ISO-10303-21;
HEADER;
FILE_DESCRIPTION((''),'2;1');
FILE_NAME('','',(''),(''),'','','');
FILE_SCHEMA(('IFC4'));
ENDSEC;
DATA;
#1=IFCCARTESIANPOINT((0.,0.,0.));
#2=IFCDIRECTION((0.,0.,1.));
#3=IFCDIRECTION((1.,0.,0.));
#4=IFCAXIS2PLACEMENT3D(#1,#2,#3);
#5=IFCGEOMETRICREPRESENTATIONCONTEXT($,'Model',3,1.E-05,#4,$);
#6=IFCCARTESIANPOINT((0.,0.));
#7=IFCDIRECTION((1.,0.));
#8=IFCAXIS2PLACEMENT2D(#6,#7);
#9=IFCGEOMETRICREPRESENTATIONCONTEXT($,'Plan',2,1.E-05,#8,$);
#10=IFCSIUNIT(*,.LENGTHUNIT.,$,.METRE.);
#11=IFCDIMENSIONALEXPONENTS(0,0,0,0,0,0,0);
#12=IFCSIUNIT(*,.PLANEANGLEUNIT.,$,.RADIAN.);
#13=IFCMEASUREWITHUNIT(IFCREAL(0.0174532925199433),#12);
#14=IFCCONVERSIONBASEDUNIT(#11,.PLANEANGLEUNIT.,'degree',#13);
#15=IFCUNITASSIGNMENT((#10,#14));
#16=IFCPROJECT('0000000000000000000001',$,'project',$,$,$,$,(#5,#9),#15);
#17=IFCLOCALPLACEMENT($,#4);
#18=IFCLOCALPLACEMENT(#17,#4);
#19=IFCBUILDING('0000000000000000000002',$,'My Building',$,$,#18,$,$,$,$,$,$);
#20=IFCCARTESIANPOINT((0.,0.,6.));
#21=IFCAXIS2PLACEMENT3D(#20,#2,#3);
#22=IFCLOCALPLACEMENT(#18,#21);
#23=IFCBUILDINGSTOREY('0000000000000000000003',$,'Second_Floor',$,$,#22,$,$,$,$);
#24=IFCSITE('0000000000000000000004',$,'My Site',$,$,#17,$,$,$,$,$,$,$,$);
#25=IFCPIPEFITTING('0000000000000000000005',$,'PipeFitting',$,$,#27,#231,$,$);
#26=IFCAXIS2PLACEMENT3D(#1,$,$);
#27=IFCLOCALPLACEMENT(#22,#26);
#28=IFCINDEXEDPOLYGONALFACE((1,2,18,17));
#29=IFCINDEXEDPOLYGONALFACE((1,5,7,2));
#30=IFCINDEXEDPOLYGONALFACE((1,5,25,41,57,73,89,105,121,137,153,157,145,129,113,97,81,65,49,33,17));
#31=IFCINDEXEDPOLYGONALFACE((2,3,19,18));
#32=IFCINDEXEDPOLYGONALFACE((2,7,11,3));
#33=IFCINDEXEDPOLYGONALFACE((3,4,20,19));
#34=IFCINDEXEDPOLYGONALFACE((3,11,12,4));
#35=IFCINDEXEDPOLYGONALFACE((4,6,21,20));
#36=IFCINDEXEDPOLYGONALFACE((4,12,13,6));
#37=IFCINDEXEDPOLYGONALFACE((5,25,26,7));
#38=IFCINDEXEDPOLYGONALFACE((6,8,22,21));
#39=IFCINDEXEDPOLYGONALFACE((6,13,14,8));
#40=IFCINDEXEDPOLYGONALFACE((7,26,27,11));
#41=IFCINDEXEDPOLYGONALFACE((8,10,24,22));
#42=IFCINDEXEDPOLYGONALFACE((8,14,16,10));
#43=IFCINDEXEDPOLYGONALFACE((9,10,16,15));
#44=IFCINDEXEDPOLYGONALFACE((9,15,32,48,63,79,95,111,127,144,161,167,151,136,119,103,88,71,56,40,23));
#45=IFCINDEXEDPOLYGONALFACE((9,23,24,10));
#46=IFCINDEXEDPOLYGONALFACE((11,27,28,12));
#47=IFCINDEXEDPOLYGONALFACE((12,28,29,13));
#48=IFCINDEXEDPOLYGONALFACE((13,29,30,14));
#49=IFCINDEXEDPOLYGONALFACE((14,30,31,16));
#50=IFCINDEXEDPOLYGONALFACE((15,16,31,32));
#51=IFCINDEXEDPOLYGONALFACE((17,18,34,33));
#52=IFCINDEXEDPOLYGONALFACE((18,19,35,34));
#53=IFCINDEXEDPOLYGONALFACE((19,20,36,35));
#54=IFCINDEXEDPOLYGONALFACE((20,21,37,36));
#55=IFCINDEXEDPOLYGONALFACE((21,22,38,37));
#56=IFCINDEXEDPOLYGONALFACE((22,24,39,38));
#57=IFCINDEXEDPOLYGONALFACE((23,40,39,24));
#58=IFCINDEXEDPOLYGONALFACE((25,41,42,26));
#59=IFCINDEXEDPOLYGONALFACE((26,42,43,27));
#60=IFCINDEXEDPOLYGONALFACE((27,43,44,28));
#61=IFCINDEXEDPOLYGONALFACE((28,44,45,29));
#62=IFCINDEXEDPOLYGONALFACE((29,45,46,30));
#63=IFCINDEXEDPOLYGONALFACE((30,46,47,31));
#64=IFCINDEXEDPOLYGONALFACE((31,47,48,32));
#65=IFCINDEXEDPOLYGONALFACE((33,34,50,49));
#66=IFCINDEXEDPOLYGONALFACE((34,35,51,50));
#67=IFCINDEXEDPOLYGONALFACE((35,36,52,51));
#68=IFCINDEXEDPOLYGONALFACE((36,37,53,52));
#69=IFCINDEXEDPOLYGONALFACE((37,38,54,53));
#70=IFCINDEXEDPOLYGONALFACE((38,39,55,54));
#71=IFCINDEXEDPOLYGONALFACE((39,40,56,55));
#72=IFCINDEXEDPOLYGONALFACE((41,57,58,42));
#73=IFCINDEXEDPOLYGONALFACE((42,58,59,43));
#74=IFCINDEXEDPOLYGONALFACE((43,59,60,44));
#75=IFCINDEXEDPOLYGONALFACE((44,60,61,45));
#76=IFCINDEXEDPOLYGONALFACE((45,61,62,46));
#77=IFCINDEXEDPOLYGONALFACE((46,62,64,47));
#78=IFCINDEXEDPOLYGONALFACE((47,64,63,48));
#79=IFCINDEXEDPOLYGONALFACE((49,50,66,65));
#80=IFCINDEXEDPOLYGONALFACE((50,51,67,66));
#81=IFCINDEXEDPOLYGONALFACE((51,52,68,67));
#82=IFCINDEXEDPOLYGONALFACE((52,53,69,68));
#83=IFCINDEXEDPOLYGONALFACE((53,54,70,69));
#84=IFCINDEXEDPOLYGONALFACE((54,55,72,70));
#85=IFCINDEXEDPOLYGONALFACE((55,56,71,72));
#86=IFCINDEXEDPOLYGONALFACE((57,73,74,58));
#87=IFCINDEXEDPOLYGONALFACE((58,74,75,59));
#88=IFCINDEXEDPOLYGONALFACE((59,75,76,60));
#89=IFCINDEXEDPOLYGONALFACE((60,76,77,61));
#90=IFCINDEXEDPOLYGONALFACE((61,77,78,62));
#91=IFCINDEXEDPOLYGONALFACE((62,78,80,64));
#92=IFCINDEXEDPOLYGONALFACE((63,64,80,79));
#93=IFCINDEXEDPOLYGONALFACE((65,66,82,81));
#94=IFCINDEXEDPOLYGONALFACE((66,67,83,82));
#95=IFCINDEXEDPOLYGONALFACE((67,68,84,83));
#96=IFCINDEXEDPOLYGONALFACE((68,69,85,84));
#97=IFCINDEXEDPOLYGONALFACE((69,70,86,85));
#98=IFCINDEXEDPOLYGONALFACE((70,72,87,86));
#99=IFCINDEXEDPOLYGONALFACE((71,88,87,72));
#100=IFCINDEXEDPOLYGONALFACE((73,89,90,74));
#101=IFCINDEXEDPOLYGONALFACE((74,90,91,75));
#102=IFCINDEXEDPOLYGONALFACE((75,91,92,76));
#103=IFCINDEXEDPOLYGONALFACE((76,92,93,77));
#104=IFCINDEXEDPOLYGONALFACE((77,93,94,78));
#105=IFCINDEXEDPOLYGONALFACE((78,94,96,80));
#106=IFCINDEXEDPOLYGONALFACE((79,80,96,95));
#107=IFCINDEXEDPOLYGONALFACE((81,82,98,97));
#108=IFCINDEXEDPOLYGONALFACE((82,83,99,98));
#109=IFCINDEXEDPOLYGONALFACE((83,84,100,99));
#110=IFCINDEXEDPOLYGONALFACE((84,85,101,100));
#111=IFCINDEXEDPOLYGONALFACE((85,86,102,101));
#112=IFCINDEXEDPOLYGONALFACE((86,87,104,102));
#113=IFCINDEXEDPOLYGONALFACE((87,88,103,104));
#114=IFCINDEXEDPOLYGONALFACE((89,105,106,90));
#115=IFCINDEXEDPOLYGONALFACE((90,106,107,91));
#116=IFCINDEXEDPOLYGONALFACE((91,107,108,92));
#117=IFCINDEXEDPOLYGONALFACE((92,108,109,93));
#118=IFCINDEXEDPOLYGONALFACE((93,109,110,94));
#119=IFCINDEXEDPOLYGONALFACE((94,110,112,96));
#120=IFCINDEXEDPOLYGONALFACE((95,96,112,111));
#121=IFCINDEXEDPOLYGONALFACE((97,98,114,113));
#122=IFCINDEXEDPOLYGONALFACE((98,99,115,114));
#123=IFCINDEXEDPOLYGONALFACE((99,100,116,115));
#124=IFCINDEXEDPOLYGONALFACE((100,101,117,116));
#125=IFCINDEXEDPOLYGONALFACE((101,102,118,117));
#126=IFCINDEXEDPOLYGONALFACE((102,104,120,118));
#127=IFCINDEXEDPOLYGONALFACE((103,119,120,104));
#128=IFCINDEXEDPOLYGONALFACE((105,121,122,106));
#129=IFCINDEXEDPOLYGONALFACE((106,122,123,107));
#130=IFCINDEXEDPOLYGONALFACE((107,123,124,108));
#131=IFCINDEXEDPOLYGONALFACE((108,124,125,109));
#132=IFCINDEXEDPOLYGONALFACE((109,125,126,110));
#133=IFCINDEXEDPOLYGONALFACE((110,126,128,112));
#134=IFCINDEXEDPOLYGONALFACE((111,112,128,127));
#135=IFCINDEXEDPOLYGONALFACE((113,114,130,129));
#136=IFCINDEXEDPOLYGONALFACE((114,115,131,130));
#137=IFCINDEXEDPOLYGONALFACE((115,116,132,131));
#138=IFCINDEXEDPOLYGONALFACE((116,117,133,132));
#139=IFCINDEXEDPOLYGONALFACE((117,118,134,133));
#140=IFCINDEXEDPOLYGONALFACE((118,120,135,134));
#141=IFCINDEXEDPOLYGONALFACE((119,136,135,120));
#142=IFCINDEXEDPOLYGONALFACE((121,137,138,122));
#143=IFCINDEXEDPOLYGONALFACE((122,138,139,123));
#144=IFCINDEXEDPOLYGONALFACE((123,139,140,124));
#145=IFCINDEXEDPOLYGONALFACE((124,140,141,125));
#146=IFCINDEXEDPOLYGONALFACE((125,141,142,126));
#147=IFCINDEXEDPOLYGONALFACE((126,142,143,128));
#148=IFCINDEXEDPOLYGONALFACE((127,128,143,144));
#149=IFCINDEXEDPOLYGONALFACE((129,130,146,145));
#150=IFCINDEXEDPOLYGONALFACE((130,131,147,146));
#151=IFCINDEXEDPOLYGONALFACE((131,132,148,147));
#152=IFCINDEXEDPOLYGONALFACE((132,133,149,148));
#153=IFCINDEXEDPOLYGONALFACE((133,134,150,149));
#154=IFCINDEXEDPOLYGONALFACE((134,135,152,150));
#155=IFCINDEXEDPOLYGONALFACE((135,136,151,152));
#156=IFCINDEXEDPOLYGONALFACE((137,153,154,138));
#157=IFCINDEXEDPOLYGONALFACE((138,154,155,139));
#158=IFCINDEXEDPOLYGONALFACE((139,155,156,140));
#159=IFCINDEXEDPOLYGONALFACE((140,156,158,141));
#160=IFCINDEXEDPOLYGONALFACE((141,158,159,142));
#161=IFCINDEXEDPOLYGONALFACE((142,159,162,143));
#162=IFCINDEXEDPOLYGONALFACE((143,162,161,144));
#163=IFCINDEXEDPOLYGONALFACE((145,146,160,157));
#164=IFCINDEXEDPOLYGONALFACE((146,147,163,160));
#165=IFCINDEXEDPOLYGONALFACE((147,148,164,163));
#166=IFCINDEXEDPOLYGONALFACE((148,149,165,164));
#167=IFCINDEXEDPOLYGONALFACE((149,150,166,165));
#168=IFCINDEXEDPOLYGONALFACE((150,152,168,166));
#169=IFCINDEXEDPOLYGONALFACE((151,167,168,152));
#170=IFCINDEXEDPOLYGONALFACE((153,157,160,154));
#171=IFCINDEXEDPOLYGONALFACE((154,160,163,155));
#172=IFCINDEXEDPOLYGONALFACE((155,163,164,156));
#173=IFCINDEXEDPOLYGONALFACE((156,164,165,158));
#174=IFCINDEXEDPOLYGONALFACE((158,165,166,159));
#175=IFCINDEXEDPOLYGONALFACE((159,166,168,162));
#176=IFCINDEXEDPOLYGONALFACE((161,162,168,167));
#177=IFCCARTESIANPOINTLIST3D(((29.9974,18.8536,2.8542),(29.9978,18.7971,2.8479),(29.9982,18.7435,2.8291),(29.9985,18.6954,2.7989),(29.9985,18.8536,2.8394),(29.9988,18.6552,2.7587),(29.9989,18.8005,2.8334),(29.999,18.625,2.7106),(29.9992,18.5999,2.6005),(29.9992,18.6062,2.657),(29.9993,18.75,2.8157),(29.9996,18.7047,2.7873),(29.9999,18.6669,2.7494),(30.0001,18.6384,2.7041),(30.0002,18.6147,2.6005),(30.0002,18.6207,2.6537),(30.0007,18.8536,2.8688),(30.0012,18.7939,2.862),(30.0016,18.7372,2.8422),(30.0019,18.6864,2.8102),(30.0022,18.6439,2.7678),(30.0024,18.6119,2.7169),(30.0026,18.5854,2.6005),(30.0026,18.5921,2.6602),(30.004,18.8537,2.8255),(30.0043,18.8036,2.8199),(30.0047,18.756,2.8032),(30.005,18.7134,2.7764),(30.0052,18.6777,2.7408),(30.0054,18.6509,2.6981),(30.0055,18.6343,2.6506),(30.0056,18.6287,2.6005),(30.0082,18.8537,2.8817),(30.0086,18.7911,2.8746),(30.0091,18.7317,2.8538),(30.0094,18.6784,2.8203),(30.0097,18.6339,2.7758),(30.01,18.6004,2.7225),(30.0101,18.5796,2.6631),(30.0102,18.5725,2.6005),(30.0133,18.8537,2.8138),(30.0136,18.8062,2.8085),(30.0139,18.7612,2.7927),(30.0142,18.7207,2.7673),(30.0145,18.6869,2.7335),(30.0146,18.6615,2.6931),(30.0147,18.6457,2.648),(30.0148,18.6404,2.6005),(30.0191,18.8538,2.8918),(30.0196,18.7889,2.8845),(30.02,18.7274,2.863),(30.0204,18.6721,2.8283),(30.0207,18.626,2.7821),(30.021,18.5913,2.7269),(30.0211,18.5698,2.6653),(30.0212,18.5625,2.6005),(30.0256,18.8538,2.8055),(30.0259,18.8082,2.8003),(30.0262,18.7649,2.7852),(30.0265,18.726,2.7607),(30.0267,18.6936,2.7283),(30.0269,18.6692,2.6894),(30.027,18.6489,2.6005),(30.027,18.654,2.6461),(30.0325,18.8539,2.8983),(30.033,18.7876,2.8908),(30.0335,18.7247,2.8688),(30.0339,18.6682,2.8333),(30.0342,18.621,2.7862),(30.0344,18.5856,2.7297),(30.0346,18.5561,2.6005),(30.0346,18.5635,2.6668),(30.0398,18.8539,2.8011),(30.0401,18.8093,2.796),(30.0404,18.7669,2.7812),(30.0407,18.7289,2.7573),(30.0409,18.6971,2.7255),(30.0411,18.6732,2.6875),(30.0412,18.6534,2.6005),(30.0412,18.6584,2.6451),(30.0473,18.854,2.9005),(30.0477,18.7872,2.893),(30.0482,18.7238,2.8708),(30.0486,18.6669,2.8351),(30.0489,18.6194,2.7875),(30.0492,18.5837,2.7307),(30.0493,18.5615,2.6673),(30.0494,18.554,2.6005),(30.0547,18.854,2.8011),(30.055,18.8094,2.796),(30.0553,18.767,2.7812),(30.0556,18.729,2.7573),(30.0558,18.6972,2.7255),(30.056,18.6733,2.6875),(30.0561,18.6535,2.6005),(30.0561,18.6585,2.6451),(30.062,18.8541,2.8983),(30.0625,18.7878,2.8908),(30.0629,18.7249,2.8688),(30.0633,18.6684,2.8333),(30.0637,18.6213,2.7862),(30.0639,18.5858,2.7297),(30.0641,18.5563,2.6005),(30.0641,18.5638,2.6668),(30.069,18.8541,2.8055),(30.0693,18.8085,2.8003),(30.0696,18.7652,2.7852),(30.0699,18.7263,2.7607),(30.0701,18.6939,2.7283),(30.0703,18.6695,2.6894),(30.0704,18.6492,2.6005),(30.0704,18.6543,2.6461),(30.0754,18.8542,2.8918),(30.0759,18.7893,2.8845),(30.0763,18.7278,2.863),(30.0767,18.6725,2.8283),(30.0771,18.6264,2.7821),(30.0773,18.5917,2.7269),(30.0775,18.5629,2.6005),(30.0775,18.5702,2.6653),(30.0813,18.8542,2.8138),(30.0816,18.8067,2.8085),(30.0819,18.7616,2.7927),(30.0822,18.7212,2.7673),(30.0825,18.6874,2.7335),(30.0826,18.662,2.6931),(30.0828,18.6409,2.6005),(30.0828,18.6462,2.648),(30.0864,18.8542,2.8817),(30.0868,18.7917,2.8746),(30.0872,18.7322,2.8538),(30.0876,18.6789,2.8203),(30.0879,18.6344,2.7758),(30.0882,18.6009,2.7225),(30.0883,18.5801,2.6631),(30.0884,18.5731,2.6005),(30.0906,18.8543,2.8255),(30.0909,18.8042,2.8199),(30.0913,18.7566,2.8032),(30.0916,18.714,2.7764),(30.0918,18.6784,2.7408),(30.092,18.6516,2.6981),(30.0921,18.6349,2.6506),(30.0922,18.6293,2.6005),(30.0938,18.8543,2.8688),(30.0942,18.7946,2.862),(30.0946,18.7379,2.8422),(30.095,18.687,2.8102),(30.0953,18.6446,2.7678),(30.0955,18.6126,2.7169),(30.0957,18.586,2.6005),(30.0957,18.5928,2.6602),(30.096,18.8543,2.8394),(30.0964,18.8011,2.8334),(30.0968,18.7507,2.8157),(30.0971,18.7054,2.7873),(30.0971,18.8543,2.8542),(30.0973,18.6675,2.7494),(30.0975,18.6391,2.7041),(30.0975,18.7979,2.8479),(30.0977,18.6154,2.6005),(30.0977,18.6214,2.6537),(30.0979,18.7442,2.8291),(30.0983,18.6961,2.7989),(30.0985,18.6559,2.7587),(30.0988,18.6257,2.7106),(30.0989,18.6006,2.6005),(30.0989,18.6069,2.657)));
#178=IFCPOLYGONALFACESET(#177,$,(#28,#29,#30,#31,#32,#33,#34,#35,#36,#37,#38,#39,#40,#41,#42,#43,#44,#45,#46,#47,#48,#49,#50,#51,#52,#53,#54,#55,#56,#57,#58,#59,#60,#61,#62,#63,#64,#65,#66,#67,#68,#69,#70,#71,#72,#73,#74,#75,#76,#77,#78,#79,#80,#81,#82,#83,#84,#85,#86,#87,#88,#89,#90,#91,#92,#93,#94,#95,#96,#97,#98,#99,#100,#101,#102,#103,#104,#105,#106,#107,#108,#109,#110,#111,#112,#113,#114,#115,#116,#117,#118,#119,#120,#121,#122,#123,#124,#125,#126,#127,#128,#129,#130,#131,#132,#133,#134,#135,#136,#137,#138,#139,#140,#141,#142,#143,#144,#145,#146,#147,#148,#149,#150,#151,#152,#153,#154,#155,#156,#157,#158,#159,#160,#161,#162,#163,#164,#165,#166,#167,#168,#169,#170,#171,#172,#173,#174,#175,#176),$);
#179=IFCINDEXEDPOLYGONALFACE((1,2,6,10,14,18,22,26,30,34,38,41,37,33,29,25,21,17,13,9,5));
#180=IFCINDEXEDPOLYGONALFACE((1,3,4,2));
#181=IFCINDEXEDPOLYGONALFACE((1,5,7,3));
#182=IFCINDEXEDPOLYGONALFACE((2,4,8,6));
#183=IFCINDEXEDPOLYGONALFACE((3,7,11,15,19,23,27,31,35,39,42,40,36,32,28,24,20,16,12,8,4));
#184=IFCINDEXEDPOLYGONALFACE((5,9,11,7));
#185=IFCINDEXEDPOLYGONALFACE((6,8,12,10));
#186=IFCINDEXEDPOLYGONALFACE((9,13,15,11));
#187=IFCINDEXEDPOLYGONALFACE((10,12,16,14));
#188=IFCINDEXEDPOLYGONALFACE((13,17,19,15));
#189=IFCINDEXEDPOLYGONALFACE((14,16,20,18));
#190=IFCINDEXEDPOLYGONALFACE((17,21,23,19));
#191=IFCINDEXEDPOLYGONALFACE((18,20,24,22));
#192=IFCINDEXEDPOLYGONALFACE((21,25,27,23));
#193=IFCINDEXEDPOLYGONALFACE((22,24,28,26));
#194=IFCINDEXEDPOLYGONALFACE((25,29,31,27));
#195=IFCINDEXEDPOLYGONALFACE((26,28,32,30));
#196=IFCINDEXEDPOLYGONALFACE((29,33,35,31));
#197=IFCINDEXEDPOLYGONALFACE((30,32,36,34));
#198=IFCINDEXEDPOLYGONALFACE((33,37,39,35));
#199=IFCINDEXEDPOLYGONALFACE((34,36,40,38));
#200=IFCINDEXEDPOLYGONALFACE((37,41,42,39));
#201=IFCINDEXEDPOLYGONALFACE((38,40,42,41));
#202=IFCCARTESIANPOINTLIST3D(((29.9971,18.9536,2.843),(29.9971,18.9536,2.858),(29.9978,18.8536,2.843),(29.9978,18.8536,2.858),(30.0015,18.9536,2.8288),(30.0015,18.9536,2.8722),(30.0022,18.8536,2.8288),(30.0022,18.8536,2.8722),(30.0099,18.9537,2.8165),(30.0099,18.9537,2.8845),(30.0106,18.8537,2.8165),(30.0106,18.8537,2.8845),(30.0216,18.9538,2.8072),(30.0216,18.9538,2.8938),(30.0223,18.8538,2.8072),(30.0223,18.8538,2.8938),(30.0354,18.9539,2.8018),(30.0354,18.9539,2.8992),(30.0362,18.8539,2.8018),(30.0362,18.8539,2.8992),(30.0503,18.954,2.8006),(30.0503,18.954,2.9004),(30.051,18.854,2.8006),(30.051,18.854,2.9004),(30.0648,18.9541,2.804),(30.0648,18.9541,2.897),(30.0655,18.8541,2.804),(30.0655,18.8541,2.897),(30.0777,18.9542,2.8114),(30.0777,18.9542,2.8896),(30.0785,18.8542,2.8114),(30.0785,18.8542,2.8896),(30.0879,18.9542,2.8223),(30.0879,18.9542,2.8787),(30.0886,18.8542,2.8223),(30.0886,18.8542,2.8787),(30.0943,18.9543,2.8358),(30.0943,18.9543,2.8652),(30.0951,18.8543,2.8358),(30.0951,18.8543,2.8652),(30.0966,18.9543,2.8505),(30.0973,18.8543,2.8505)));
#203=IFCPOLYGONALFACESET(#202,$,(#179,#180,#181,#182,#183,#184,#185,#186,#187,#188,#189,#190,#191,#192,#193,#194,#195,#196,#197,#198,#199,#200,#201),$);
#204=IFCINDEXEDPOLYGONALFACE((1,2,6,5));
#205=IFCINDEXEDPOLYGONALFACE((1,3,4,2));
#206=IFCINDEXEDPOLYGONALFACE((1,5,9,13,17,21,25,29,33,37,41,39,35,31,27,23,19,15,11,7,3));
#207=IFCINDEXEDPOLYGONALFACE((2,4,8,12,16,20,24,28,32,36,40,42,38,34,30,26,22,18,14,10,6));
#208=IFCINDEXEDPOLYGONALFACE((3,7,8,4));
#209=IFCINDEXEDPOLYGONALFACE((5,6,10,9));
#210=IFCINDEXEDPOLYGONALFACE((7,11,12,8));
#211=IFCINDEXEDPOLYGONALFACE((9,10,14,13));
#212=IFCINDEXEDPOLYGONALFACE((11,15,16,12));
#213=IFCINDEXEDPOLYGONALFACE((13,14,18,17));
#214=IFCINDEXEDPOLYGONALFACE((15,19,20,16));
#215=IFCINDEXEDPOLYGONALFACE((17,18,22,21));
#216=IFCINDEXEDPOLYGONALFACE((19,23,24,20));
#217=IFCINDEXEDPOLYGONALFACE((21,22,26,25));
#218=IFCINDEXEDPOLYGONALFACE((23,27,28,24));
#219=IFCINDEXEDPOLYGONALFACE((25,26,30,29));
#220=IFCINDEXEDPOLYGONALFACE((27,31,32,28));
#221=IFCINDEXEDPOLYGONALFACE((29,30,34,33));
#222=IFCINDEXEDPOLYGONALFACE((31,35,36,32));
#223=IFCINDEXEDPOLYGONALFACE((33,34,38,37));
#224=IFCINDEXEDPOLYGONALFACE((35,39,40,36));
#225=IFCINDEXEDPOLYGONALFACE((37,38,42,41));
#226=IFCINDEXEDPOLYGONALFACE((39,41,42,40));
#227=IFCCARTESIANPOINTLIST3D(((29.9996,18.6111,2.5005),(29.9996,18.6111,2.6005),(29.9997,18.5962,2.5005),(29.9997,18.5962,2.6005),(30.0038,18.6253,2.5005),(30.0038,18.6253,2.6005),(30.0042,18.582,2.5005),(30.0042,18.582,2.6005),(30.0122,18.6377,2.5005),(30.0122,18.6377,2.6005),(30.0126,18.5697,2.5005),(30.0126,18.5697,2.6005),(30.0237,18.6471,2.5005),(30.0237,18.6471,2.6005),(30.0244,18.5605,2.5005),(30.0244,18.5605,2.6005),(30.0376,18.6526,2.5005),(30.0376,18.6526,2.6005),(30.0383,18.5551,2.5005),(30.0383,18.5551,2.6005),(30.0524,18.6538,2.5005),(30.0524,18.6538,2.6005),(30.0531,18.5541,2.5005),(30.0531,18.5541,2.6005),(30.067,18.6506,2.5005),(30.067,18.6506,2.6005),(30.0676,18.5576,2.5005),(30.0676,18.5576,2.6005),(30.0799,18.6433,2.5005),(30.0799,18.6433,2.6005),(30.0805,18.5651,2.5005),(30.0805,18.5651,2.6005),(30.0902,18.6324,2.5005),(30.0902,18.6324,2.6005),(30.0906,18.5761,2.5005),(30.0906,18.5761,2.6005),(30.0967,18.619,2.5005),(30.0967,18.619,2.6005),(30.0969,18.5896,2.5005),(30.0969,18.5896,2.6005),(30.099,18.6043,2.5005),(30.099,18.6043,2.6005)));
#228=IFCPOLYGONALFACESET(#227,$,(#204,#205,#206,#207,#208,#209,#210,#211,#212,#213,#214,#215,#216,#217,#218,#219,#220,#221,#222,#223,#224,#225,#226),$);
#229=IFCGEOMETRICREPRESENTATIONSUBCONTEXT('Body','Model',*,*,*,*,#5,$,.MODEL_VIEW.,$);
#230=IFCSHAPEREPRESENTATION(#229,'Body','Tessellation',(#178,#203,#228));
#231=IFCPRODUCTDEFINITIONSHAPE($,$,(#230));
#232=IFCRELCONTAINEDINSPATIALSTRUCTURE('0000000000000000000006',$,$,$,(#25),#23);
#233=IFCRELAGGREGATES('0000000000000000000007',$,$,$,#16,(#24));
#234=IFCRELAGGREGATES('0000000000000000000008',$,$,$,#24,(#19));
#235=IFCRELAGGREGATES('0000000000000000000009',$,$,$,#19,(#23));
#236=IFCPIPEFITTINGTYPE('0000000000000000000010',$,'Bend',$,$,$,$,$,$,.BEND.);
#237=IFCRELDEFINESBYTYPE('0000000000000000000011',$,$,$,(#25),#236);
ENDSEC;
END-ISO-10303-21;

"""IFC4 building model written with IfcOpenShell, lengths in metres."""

from ifc_helpers import new_model, entity, si_unit, converted_unit, frame, origin_with_axes, origin_2d_with_axis, place, context, subcontext, project, spatial, circle, extrude, source, transform, mapped, type_object, type_shapes, element, save


model = new_model("IFC4")

# Units and contexts
model_context = context("Model", 3, precision=1e-05, world=origin_with_axes())
plan_context = context("Plan", 2, precision=1e-05, world=origin_2d_with_axis())
body_context_1 = subcontext(model_context, "Body", "Model", "MODEL_VIEW")
ifc_project = project(units=[si_unit("LENGTHUNIT", "METRE"), converted_unit("PLANEANGLEUNIT", "degree", entity("IfcReal", 0.0174532925199433), si_unit("PLANEANGLEUNIT", "RADIAN"), dimensions=[0, 0, 0, 0, 0, 0, 0])], contexts=[model_context, plan_context])

# Site, building, storey
site_placement = place(None, origin_with_axes())
site = spatial("IfcSite", under=ifc_project, at=site_placement, Name="My Site")
building_placement = place(site_placement, origin_with_axes())
building = spatial("IfcBuilding", under=site, at=building_placement, Name="My Building")
storey_placement = place(building_placement, frame((0.0, 0.0, 6.0), z_axis=(0.0, 0.0, 1.0), x_axis=(1.0, 0.0, 0.0)))
storey = spatial("IfcBuildingStorey", under=building, at=storey_placement, Name="Second_Floor")

# Pipe fitting
pipe_fitting_type = type_object("IfcPipeFittingType", Name="Bend", PredefinedType="BEND")
shared_shape_1 = source(origin_with_axes(), body_context_1, "Body", "SolidModel", [
    entity("IfcSweptDiskSolid", entity("IfcIndexedPolyCurve", entity("IfcCartesianPointList3D", [[0.0, 0.0, -0.1], [0.0, 0.0732, -0.2768], [0.0, 0.25, -0.35]]), [entity("IfcArcIndex", [1, 2, 3])]), 0.05),
    extrude(circle(Radius=0.05), origin_with_axes(), (0.0, 0.0, -1.0), 0.1),
    extrude(circle(Radius=0.05), frame((0.0, 0.25, -0.35), z_axis=(0.0, 1.0, 0.0), x_axis=(1.0, 0.0, 0.0)), (0.0, 0.0, 1.0), 0.1),
])
type_shapes(pipe_fitting_type, [shared_shape_1])
for number, where, z_axis, x_axis, name in (
    (1, (30.0466, 18.954, 2.8505), (-0.007084, 0.999975, 0.0), (0.999975, 0.007084, 0.0), "PipeFitting"),
):
    element("IfcPipeFitting", number, at=place(storey_placement, frame(where, z_axis=z_axis, x_axis=x_axis)), inside=storey, type_object=pipe_fitting_type, Name=name, context=body_context_1, shape_type="MappedRepresentation", body=[
        mapped(shared_shape_1, transform((0.0, 0.0, 0.0), x_axis=(1.0, 0.0, 0.0), y_axis=(0.0, 1.0, 0.0), z_axis=(0.0, 0.0, 1.0), scale=1.0)),
    ])

save(model, "model.ifc")
